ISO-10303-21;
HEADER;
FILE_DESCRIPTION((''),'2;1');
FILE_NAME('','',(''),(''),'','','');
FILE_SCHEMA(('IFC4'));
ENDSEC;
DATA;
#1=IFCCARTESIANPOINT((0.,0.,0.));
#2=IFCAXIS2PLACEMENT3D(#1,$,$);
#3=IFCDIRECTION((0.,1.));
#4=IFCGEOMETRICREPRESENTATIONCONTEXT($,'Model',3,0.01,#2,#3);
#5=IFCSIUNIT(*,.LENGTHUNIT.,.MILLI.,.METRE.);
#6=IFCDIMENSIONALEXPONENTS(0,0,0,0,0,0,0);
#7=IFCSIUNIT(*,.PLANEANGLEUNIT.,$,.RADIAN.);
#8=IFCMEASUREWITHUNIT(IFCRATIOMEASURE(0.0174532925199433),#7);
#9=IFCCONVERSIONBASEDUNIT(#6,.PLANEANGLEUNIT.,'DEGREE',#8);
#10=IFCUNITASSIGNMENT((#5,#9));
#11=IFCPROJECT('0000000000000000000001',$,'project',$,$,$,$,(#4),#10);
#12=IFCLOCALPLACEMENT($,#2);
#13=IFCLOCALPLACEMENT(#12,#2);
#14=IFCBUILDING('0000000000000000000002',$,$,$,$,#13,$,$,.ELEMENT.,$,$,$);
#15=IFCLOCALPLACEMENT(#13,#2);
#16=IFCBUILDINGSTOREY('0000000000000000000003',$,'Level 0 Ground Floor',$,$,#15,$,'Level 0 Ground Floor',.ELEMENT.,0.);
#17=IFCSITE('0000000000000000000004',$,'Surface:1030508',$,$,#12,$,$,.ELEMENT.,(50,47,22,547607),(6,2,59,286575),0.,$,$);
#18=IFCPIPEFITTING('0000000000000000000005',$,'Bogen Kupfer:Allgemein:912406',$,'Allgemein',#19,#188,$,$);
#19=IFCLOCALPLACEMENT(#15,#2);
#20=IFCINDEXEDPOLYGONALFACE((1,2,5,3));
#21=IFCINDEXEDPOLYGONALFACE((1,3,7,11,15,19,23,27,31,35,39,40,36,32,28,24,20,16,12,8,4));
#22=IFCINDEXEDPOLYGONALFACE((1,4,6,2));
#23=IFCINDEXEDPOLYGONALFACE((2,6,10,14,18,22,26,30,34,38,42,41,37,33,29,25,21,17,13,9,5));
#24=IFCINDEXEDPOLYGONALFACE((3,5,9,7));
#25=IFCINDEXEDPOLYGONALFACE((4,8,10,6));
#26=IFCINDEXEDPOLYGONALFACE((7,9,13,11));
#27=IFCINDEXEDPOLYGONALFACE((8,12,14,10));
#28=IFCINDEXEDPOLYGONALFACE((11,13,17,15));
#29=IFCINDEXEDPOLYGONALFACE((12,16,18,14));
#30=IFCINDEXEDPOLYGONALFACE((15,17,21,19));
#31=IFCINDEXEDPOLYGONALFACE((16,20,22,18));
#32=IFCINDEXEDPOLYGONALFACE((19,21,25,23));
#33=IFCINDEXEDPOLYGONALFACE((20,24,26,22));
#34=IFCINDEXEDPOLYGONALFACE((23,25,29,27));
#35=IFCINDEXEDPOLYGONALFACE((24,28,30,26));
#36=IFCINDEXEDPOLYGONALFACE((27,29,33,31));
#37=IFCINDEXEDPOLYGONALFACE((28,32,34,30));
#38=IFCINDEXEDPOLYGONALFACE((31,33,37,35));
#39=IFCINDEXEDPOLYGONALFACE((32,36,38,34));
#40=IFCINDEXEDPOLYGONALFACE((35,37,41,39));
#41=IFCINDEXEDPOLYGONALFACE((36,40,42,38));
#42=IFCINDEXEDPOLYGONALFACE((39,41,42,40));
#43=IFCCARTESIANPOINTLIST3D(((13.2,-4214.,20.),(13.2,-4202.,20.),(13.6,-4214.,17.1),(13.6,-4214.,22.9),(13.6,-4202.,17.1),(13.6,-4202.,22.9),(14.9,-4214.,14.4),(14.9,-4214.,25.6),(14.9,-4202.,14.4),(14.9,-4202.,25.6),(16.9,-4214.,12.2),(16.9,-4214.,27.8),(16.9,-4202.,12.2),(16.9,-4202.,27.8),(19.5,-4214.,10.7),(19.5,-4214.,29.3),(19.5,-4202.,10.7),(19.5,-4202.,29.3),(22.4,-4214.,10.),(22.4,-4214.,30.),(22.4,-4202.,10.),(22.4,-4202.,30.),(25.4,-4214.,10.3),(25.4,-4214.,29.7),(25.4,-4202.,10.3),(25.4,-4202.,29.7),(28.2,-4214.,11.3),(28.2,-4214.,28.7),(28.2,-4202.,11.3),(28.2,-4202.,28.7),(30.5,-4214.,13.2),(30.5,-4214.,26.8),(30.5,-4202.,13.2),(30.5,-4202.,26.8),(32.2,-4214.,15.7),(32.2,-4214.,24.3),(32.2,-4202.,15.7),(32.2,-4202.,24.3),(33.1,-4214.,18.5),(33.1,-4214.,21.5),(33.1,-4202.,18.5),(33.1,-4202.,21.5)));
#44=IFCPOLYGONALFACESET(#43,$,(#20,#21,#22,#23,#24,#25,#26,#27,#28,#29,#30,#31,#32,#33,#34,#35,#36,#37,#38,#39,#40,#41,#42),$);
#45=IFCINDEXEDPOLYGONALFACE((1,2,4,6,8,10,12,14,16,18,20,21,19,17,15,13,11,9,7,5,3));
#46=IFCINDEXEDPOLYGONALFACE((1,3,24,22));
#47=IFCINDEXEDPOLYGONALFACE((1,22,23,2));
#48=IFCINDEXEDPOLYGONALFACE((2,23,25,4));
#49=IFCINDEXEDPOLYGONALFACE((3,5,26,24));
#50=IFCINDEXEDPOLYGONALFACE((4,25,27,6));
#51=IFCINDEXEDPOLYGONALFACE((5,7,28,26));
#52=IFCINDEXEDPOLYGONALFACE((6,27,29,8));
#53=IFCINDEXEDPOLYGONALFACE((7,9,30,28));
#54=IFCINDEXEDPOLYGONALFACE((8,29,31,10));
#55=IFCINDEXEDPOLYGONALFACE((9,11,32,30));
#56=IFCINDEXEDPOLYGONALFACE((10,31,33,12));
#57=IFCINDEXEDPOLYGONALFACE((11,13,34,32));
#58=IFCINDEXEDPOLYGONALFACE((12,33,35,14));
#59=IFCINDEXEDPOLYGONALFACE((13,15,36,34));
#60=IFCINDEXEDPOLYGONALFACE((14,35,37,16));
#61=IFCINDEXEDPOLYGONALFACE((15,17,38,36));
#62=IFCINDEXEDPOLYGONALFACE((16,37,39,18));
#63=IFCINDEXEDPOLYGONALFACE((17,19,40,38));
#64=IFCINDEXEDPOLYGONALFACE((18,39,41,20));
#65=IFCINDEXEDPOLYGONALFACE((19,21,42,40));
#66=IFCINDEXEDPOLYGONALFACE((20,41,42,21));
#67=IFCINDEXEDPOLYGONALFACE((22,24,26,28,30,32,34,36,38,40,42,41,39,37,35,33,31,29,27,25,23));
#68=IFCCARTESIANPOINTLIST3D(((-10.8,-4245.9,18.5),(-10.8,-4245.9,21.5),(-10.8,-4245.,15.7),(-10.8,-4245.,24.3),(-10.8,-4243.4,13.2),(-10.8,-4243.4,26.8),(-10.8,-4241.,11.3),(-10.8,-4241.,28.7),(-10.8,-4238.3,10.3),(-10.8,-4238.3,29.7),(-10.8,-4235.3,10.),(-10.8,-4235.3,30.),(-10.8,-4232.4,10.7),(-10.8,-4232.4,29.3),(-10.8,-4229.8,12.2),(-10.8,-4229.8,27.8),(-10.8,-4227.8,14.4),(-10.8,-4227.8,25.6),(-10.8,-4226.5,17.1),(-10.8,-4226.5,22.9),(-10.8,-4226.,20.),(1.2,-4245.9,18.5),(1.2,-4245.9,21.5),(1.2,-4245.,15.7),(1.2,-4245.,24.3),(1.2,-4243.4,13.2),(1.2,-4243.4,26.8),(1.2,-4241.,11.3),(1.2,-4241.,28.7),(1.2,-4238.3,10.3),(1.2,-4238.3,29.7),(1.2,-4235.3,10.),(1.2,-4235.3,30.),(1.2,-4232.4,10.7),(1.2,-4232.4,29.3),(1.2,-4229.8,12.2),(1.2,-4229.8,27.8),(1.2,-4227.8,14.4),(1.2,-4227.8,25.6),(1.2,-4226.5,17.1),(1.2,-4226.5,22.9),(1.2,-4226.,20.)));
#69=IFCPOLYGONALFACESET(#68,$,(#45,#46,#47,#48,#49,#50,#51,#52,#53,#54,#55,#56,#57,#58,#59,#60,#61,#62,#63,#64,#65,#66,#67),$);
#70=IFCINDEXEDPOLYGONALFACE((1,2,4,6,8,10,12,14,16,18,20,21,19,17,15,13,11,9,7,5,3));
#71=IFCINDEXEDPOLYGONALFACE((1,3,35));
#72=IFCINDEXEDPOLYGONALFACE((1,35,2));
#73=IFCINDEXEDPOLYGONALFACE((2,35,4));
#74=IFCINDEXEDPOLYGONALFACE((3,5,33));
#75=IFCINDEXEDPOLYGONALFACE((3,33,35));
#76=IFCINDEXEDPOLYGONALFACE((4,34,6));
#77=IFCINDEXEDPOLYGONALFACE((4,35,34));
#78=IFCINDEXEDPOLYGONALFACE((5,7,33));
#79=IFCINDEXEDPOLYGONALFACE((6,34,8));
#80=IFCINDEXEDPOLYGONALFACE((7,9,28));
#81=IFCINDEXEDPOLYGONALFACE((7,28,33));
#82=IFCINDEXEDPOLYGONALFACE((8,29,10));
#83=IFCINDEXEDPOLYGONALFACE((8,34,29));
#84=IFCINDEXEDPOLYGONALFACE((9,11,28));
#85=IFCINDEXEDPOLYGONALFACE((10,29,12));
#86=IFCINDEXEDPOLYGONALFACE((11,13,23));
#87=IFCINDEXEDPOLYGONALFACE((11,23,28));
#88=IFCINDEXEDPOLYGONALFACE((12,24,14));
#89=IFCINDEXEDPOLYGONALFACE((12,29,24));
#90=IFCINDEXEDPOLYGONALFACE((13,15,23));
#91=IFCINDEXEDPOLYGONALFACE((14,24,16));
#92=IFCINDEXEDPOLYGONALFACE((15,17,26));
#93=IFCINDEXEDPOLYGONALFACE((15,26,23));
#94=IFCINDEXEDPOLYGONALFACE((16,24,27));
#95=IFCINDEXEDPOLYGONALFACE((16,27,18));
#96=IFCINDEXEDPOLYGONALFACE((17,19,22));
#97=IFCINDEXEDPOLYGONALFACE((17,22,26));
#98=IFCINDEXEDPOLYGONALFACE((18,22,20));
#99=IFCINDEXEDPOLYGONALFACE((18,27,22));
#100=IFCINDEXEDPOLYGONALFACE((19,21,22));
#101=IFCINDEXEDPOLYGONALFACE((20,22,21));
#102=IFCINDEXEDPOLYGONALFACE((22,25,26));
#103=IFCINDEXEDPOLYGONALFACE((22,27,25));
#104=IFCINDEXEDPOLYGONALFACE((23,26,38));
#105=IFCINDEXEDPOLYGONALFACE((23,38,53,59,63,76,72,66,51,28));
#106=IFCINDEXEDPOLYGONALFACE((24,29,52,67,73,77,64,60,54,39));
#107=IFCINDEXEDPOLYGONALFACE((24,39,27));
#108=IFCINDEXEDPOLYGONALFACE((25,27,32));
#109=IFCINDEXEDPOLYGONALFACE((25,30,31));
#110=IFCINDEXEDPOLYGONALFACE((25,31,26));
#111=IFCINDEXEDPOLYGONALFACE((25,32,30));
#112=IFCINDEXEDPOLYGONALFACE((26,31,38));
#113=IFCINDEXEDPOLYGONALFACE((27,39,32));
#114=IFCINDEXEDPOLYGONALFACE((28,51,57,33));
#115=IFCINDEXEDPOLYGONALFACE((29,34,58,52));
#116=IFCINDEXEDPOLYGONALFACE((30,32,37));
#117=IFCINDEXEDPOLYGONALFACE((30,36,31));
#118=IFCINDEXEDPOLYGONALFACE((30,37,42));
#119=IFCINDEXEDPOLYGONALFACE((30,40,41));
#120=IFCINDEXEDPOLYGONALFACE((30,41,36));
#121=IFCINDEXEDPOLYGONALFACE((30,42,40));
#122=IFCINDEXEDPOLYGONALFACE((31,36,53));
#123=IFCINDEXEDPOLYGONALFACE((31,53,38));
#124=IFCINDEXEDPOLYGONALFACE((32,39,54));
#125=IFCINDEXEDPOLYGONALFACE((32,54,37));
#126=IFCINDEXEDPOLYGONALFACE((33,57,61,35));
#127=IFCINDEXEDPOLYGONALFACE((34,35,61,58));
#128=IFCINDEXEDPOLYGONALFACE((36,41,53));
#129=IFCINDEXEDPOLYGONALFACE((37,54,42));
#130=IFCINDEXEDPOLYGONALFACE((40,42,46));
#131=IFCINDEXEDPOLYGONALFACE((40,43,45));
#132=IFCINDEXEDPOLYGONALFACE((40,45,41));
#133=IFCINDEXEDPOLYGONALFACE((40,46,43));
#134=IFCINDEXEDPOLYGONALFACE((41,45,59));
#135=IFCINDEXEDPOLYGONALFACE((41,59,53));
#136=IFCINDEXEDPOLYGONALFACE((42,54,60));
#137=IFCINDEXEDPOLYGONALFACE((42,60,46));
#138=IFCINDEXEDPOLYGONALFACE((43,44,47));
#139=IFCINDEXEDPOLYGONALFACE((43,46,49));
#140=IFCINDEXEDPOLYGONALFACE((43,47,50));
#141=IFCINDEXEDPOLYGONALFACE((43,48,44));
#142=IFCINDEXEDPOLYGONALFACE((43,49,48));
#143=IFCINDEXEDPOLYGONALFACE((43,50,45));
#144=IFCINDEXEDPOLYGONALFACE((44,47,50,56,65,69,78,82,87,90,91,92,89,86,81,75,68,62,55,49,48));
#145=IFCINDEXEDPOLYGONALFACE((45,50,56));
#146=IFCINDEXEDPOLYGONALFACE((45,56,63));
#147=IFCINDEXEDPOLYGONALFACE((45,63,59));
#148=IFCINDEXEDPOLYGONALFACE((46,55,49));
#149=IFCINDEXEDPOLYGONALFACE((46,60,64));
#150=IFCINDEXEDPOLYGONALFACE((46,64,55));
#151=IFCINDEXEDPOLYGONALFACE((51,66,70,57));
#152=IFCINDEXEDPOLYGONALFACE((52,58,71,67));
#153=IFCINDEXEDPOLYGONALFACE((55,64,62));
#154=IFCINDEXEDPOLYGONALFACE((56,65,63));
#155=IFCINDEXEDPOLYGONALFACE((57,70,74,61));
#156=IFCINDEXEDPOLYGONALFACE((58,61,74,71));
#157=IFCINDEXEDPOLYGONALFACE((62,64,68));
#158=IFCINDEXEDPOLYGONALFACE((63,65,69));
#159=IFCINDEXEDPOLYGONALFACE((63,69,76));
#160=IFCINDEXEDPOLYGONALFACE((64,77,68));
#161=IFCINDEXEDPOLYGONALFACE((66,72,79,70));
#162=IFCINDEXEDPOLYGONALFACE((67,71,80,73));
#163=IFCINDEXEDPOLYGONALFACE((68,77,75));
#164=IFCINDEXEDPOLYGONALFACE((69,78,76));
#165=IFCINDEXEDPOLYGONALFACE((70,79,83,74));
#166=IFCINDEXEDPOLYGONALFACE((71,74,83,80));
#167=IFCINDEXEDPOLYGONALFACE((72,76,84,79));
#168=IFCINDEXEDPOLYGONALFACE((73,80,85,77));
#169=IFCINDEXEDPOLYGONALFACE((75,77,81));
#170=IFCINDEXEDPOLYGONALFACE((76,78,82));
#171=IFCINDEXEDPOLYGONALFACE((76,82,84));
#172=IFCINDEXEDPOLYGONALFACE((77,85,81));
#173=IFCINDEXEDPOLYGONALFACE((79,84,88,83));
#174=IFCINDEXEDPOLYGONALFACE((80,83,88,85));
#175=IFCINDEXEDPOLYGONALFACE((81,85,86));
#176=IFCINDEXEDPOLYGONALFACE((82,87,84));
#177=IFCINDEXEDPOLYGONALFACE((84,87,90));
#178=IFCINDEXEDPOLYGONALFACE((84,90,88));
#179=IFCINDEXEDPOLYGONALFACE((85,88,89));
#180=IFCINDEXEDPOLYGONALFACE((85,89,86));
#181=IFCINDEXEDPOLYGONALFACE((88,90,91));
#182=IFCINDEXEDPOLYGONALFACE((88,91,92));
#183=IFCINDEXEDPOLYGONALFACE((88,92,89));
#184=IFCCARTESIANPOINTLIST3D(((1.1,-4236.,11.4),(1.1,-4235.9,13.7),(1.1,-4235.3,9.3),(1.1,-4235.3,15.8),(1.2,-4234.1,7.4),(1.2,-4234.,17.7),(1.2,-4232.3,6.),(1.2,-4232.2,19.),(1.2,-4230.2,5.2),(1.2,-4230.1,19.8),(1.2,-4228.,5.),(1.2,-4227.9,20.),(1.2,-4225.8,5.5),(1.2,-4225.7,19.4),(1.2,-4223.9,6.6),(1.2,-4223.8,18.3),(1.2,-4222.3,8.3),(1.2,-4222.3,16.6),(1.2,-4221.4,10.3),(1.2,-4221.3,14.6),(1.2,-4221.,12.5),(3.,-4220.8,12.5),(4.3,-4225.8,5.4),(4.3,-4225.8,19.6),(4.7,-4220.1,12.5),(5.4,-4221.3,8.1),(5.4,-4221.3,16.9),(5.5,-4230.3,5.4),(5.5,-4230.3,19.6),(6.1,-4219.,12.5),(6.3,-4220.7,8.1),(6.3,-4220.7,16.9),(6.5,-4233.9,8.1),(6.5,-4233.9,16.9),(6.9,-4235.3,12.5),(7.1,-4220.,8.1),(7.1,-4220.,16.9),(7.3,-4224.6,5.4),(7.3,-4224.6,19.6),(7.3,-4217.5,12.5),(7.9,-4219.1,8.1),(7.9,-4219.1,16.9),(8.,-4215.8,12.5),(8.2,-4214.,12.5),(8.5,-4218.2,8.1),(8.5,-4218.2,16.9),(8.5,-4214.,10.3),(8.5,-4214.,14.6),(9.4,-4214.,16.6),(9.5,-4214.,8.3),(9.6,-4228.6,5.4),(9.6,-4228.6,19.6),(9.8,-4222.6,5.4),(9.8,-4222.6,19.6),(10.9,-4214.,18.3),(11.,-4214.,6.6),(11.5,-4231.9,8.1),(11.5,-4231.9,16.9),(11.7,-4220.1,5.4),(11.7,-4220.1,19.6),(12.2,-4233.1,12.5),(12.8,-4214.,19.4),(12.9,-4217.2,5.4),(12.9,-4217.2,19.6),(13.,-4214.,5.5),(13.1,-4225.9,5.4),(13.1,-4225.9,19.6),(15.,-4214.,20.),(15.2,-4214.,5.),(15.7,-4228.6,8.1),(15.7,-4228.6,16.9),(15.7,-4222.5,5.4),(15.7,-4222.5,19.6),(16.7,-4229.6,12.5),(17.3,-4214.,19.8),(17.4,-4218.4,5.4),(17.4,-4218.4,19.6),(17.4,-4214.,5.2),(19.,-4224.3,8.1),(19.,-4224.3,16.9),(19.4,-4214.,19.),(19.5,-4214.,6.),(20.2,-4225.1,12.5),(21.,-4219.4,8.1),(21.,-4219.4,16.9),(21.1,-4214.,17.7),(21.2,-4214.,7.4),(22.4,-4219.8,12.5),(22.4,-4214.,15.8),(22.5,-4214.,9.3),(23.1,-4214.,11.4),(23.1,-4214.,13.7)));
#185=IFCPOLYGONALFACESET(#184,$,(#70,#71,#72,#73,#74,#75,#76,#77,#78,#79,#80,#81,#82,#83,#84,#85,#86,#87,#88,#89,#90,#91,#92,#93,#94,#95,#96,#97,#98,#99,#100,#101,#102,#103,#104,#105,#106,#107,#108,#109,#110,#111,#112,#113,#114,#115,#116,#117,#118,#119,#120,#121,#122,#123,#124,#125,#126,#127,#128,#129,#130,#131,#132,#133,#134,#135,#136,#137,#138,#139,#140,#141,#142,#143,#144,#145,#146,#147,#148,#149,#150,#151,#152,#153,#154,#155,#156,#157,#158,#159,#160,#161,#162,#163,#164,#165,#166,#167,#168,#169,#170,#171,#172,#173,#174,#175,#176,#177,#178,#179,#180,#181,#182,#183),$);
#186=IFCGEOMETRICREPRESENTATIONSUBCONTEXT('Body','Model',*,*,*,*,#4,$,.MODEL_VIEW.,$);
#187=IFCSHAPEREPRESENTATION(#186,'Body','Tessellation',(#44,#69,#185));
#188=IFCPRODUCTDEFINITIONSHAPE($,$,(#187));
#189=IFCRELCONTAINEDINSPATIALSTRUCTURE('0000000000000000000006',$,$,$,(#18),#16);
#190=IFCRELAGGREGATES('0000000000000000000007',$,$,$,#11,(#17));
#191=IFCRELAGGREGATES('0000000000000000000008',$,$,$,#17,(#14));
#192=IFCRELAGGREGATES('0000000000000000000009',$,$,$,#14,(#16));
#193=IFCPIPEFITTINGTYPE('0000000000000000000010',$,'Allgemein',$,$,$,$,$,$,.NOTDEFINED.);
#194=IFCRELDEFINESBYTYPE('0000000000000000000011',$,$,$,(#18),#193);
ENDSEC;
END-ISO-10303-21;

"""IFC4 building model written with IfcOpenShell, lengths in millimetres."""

from ifc_helpers import new_model, entity, si_unit, converted_unit, direction, frame, frame_2d, origin, place, context, subcontext, project, spatial, circle, extrude, source, transform, mapped, type_object, type_shapes, element, save


model = new_model("IFC4")

# Units and contexts
model_context = context("Model", 3, precision=0.01, world=origin(), true_north=direction((0.0, 1.0)))
body_context = subcontext(model_context, "Body", "Model", "MODEL_VIEW")
ifc_project = project(units=[si_unit("LENGTHUNIT", "METRE", prefix="MILLI"), converted_unit("PLANEANGLEUNIT", "DEGREE", entity("IfcRatioMeasure", 0.0174532925199433), si_unit("PLANEANGLEUNIT", "RADIAN"), dimensions=[0, 0, 0, 0, 0, 0, 0])], contexts=[model_context])

# Site, building, storey
site_placement = place(None, origin())
site = spatial("IfcSite", under=ifc_project, at=site_placement, Name="Surface:1030508", CompositionType="ELEMENT", RefLatitude=(50, 47, 22, 547607), RefLongitude=(6, 2, 59, 286575), RefElevation=0.0)
building_placement = place(site_placement, origin())
building = spatial("IfcBuilding", under=site, at=building_placement, CompositionType="ELEMENT")
storey_placement = place(building_placement, origin())
storey = spatial("IfcBuildingStorey", under=building, at=storey_placement, Name="Level 0 Ground Floor", LongName="Level 0 Ground Floor", CompositionType="ELEMENT", Elevation=0.0)

# Pipe fitting
pipe_fitting_type_1 = type_object("IfcPipeFittingType", Name="Allgemein", PredefinedType="NOTDEFINED")
ifc_direction_1 = entity("IfcDirection", [0.0, 0.0, -1.0])
trimmed_curve_1 = entity("IfcTrimmedCurve", entity("IfcCircle", entity("IfcAxis2Placement2D", entity("IfcCartesianPoint", [-14.5, 0.0]), entity("IfcDirection", [0.0, 1.0])), 14.5), [entity("IfcParameterValue", 270.0)], [entity("IfcParameterValue", 0.0)], True, "PARAMETER")
shared_shape_1 = source(origin(), body_context, "Body", "SolidModel", [
    extrude(circle(Radius=10.0, at=frame_2d((0.0, 0.0), x_axis=(1.0, 0.0))), frame((0.0, 22.0, 0.0), z_axis=(0.0, 1.0, 0.0), x_axis=(-1.0, 0.0, 0.0)), (0.0, 0.0, 1.0), 12.0),
    extrude(circle(Radius=10.0, at=frame_2d((0.0, 0.0), x_axis=(1.0, 0.0))), frame((-34.0, 0.0, 0.0), z_axis=(1.0, 0.0, 0.0), x_axis=(0.0, 1.0, 0.0)), (0.0, 0.0, 1.0), 12.0),
    entity("IfcSurfaceCurveSweptAreaSolid", entity("IfcCircleProfileDef", "AREA", None, entity("IfcAxis2Placement2D", entity("IfcCartesianPoint", [0.0, 7.5]), entity("IfcDirection", [1.0, 0.0])), 7.5), entity("IfcAxis2Placement3D", entity("IfcCartesianPoint", [-7.5, 22.0, 0.0]), ifc_direction_1, entity("IfcDirection", [1.0, 0.0, 0.0])), trimmed_curve_1, 0.0, 90.0, entity("IfcSurfaceOfLinearExtrusion", entity("IfcArbitraryOpenProfileDef", "CURVE", None, trimmed_curve_1), entity("IfcAxis2Placement3D", entity("IfcCartesianPoint", [0.0, 0.0, -304.8])), ifc_direction_1, 1.0)),
])
type_shapes(pipe_fitting_type_1, [shared_shape_1])
pipe_fitting_1_placement = place(storey_placement, frame((23.2, -4236.0, 20.0)))
element("IfcPipeFitting", 1, at=pipe_fitting_1_placement, inside=storey, type_object=pipe_fitting_type_1, Name="Bogen Kupfer:Allgemein:912406", ObjectType="Allgemein", context=body_context, shape_type="MappedRepresentation", body=[
    mapped(shared_shape_1, transform((0.0, 0.0, 0.0), scale=1.0)),
])

save(model, "model.ifc")
